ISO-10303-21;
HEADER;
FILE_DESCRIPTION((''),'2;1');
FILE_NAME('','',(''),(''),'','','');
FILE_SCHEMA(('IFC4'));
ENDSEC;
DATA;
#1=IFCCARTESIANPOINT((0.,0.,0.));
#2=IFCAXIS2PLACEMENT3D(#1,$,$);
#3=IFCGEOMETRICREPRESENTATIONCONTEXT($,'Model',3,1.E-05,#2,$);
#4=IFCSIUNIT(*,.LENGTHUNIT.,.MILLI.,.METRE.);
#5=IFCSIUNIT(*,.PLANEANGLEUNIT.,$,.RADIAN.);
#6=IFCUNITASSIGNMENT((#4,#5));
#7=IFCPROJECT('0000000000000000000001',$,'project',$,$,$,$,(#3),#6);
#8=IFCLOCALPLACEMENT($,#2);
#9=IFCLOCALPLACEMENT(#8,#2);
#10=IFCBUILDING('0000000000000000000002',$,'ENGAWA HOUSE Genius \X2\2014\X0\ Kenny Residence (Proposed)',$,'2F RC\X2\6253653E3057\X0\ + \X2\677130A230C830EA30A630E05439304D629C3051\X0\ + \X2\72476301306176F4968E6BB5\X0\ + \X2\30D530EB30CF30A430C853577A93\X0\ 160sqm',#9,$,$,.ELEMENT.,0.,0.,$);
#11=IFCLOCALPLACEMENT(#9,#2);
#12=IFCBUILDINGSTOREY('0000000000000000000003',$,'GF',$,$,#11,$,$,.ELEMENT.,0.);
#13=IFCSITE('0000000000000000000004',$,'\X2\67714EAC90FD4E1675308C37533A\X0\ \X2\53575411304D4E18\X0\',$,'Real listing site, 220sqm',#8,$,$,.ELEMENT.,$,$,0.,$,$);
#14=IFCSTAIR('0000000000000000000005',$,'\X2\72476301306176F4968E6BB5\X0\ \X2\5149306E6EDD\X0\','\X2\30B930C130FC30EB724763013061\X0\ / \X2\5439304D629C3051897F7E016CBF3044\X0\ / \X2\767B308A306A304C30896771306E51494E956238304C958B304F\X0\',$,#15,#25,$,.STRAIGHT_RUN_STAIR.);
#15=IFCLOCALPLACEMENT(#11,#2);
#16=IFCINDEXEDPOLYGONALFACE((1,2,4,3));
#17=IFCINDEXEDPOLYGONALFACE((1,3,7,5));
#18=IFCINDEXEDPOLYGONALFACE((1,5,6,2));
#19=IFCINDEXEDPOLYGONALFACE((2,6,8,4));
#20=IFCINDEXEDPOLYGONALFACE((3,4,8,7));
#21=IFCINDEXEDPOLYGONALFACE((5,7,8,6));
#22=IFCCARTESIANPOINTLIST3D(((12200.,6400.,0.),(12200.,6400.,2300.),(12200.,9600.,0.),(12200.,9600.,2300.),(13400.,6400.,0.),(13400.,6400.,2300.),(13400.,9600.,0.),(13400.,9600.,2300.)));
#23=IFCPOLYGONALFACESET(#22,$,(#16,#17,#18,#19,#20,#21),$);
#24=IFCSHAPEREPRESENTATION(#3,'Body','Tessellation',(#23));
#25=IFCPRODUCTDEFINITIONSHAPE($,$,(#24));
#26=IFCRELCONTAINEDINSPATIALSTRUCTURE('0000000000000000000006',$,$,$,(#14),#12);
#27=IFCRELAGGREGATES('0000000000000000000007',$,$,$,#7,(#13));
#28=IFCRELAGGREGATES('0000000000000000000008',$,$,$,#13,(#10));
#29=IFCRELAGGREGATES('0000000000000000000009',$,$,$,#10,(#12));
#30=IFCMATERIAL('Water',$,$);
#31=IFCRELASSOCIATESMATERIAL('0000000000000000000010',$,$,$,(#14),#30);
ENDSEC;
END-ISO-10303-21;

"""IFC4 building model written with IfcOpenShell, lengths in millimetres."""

from ifc_helpers import new_model, si_unit, frame, frame_2d, origin, place, context, project, spatial, rectangle, extrude, material, element, save


model = new_model("IFC4")

# Units and contexts
model_context = context("Model", 3, precision=1e-05, world=origin())
ifc_project = project(units=[si_unit("LENGTHUNIT", "METRE", prefix="MILLI"), si_unit("PLANEANGLEUNIT", "RADIAN")], contexts=[model_context])

# Site, building, storey
site_placement = place(None, origin())
site = spatial("IfcSite", under=ifc_project, at=site_placement, Name="東京都世田谷区 南向き丘", ObjectType="Real listing site, 220sqm", CompositionType="ELEMENT", RefElevation=0.0)
building_placement = place(site_placement, origin())
building = spatial("IfcBuilding", under=site, at=building_placement, Name="ENGAWA HOUSE Genius — Kenny Residence (Proposed)", ObjectType="2F RC打放し + 東アトリウム吹き抜け + 片持ち直階段 + フルハイト南窓 160sqm", CompositionType="ELEMENT", ElevationOfRefHeight=0.0, ElevationOfTerrain=0.0)
storey_placement = place(building_placement, origin())
storey = spatial("IfcBuildingStorey", under=building, at=storey_placement, Name="GF", CompositionType="ELEMENT", Elevation=0.0)

# Stair
ifc_material_1 = material(Name="Water")
stair_placement = place(storey_placement, frame((6100.0, 3200.0, 0.0)))
element("IfcStair", 1, at=stair_placement, inside=storey, material=ifc_material_1, Name="片持ち直階段 光の滝", Description="スチール片持ち / 吹き抜け西縁沿い / 登りながら東の光井戸が開く", PredefinedType="STRAIGHT_RUN_STAIR", context=model_context, shape_type="SweptSolid", body=[
    extrude(rectangle(XDim=1200.0, YDim=3200.0, at=frame_2d((600.0, 1600.0))), frame((6100.0, 3200.0, 0.0)), (0.0, 0.0, 1.0), 2300.0),
])

save(model, "model.ifc")
